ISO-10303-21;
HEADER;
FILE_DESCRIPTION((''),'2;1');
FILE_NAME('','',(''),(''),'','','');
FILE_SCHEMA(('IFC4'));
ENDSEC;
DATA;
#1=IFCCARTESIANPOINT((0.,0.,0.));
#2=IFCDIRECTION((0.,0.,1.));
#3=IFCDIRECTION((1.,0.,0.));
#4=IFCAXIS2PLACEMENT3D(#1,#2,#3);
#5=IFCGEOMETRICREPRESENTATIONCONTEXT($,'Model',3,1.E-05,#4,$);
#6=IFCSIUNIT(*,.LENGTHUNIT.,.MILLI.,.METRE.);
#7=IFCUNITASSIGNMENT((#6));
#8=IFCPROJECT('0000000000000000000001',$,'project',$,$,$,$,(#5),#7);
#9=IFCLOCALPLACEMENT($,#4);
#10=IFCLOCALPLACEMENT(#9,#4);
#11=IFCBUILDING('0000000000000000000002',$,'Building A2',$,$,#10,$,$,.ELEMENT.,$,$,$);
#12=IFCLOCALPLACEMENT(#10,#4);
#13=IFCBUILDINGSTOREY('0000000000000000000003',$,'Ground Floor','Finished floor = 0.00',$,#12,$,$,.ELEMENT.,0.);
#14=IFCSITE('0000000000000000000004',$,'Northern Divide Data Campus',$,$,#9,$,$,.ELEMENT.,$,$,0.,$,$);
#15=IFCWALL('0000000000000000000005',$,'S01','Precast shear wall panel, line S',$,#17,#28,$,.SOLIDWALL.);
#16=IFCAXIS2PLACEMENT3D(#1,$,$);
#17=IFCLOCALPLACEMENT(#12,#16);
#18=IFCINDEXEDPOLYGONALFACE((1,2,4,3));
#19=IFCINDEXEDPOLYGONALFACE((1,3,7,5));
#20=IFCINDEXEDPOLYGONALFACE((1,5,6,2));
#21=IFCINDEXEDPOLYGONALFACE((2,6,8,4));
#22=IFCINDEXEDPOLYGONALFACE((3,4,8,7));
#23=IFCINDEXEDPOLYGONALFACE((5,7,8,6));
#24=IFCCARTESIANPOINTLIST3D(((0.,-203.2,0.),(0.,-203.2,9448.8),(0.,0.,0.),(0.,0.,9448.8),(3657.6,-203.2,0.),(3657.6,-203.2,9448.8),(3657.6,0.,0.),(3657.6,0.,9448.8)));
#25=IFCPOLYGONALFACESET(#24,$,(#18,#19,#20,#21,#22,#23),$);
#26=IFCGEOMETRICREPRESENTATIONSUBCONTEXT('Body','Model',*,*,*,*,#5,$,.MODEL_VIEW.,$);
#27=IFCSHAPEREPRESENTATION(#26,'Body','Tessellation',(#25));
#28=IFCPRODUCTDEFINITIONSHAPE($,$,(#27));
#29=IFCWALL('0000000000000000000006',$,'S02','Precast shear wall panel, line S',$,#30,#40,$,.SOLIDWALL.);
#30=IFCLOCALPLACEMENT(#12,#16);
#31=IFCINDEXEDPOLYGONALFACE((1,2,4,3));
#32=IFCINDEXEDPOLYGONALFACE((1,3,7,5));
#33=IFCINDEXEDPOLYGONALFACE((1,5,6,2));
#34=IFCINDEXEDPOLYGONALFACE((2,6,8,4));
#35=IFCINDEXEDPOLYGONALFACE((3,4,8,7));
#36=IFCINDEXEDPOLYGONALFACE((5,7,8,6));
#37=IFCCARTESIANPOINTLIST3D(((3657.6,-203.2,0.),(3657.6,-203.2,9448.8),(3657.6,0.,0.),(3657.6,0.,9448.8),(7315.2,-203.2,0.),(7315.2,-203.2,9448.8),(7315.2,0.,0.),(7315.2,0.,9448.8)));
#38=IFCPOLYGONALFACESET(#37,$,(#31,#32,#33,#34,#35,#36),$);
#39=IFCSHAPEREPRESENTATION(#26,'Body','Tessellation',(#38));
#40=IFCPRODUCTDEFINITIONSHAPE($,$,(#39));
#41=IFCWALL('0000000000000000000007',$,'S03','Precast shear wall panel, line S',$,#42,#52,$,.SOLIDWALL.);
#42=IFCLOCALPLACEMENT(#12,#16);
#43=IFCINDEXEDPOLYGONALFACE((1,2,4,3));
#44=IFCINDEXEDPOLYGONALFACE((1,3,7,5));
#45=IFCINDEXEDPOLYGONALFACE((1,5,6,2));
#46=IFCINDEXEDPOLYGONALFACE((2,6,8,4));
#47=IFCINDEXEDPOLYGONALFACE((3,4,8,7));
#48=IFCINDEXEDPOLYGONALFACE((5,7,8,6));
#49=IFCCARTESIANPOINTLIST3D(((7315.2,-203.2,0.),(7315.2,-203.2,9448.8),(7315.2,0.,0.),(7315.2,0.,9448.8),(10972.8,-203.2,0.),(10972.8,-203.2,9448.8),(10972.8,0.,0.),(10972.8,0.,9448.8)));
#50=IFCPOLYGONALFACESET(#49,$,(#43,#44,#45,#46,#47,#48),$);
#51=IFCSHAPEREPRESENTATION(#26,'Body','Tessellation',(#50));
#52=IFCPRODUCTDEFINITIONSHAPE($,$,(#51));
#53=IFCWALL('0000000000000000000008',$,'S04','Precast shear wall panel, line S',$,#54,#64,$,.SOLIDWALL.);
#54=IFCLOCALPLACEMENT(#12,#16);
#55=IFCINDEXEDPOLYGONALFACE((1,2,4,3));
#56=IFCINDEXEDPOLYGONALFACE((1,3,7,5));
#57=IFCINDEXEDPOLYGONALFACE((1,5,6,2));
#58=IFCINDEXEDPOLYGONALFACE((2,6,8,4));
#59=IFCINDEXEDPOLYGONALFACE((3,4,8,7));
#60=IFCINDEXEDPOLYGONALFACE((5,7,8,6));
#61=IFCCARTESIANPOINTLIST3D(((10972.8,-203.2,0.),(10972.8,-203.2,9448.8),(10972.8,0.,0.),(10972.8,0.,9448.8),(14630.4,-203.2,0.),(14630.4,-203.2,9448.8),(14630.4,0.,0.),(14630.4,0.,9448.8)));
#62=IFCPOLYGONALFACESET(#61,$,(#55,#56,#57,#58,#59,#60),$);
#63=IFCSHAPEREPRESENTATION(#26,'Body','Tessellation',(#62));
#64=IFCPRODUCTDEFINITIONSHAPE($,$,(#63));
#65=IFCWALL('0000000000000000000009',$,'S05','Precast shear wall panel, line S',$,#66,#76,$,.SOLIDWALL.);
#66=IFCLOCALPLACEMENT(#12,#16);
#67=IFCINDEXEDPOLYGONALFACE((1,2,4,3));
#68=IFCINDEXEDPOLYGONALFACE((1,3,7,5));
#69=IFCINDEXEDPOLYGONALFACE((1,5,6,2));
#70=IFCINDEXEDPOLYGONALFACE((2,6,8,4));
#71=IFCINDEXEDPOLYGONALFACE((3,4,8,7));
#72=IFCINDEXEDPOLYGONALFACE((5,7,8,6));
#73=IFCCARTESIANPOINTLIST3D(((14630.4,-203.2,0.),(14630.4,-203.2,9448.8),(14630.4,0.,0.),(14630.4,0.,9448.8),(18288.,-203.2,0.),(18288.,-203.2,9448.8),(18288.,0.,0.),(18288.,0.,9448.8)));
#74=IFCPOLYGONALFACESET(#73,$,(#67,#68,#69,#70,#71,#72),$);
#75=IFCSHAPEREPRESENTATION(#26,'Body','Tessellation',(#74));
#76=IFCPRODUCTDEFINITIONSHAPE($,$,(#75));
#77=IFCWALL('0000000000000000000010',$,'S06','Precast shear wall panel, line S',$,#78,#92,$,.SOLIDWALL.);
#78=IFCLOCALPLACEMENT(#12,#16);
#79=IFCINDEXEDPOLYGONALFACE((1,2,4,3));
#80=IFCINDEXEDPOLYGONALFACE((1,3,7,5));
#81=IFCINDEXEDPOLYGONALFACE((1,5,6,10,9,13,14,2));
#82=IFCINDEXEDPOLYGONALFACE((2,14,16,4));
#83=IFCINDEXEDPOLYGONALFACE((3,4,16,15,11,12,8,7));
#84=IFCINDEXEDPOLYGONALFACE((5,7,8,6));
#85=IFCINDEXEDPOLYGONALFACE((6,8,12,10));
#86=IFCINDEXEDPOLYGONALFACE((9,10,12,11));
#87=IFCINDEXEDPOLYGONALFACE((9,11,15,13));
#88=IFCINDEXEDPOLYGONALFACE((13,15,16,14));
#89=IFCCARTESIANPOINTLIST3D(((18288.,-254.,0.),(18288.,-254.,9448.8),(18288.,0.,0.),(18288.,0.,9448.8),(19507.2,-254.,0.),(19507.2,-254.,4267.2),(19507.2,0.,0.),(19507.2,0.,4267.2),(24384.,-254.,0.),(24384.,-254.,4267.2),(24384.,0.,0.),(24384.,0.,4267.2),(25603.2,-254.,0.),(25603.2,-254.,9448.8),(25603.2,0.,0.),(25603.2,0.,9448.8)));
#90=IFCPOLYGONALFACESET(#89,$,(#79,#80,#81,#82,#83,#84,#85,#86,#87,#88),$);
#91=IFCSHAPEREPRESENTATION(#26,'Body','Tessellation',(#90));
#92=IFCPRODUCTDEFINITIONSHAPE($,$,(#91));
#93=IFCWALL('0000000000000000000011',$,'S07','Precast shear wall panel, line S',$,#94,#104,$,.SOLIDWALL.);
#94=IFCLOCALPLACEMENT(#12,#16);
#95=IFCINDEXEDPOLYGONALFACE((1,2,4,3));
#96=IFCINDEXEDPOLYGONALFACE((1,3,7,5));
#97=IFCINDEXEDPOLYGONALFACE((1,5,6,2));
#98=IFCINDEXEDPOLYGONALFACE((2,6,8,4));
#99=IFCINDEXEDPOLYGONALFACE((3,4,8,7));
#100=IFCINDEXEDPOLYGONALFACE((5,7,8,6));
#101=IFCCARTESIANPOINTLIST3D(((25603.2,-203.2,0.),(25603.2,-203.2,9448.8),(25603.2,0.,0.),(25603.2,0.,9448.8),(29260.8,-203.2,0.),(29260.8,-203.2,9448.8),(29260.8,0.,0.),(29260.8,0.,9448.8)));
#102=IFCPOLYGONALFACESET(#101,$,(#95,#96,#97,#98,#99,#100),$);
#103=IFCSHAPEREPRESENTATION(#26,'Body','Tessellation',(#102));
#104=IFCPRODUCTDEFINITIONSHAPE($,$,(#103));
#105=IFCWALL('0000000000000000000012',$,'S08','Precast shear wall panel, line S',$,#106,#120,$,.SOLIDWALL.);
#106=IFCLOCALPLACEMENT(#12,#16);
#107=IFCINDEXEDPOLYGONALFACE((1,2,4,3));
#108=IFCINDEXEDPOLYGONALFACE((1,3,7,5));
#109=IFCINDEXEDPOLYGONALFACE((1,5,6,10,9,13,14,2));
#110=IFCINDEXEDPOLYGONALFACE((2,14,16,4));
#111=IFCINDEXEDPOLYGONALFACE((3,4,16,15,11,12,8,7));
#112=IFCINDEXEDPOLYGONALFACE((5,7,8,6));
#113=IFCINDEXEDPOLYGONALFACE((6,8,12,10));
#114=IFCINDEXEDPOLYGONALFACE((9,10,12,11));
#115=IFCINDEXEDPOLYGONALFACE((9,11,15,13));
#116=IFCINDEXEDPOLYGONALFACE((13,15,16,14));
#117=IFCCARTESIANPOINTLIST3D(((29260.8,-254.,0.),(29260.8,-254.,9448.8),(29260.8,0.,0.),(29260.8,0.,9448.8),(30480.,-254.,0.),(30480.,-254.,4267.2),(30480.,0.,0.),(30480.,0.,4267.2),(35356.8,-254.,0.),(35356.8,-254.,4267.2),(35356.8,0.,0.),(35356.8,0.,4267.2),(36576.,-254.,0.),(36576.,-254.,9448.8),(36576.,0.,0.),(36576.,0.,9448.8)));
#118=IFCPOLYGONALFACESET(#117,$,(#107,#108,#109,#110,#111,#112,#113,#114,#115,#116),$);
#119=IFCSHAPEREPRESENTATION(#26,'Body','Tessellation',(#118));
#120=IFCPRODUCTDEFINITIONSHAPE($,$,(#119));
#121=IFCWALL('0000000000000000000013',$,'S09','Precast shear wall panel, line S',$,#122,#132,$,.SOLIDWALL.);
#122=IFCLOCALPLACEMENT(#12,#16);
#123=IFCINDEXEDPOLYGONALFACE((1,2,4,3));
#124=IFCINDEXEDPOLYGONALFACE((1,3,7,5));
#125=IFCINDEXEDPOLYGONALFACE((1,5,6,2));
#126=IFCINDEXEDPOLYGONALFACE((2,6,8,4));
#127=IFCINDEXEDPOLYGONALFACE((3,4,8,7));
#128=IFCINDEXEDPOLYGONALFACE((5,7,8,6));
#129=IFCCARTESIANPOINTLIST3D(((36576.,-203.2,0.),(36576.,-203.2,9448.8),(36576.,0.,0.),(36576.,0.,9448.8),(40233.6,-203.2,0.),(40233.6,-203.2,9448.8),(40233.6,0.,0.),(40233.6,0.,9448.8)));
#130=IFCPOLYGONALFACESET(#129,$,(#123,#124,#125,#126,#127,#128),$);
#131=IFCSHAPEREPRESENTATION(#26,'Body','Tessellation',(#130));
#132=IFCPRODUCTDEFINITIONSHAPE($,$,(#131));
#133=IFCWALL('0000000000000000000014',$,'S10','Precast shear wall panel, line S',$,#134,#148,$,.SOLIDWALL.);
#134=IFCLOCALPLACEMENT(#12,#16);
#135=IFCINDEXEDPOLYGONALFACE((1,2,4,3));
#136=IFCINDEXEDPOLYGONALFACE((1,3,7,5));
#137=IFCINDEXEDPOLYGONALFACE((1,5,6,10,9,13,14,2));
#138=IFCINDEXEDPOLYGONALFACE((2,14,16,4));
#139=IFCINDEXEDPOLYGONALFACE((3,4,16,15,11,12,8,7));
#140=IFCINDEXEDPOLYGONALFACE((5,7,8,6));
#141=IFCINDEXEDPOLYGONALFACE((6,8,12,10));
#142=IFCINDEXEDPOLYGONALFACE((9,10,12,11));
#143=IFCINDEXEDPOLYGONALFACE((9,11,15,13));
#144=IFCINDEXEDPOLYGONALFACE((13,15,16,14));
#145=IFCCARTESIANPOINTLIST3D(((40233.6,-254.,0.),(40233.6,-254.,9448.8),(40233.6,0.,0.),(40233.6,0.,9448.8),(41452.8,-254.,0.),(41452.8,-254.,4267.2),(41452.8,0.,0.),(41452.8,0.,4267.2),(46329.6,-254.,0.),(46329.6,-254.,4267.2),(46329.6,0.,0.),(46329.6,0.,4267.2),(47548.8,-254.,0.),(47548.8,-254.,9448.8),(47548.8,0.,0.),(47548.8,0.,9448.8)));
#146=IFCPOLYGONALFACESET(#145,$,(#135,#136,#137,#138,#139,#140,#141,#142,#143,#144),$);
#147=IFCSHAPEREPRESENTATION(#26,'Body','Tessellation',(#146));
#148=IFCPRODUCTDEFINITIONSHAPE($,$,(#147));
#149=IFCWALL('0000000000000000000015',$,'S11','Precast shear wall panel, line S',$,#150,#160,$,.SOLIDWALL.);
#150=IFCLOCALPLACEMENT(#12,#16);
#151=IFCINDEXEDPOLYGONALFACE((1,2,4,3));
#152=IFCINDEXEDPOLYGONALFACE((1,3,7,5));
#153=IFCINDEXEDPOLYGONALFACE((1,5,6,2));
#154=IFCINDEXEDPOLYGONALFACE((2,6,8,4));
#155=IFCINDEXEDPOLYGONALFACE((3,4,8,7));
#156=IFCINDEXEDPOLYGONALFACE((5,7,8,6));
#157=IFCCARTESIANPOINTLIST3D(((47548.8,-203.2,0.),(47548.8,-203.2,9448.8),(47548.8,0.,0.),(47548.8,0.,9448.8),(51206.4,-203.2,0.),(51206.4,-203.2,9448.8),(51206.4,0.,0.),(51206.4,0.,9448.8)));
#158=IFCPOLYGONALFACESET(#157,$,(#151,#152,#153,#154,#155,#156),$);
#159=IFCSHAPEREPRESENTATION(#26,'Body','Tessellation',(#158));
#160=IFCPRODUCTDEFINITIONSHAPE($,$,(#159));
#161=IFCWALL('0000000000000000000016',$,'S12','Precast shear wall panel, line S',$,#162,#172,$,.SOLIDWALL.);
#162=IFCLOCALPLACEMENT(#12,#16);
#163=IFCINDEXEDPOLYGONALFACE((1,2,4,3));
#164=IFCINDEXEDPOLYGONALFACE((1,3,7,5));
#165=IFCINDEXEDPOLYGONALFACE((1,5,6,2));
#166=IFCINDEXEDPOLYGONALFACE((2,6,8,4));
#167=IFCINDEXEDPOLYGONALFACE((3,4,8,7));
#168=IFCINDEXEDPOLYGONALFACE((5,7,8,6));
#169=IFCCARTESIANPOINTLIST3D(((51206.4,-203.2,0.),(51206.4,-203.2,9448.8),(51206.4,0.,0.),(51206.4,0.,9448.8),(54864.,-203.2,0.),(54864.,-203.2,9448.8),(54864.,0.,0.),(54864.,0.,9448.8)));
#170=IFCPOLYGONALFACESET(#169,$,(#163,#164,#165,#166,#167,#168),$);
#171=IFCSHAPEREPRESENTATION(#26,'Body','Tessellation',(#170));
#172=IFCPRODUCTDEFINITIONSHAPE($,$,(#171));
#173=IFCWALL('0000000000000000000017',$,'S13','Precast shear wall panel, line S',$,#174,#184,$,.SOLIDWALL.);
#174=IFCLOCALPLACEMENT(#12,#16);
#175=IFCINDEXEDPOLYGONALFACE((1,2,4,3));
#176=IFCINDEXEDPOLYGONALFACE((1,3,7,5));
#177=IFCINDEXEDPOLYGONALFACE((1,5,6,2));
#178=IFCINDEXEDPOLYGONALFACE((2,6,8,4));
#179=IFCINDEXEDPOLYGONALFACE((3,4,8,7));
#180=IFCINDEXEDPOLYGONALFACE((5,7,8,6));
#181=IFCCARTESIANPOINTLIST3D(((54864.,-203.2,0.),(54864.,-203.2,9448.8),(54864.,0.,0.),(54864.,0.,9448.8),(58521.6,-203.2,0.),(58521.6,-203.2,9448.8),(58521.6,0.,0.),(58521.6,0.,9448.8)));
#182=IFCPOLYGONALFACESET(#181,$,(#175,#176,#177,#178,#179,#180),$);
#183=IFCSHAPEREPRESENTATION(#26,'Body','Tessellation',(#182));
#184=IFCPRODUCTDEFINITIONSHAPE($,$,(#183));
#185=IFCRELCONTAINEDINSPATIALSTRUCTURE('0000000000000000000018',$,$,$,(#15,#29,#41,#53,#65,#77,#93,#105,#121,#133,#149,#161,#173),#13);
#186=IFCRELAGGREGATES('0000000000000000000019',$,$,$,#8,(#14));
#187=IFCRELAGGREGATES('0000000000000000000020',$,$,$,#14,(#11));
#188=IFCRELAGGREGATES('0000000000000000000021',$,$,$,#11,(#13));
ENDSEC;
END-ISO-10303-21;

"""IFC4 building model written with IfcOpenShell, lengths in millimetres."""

from ifc_helpers import new_model, si_unit, origin, origin_with_axes, place, context, subcontext, project, spatial, polyline, outline, extrude, element, save


model = new_model("IFC4")

# Units and contexts
model_context = context("Model", 3, precision=1e-05, world=origin_with_axes())
body_context = subcontext(model_context, "Body", "Model", "MODEL_VIEW")
ifc_project = project(units=[si_unit("LENGTHUNIT", "METRE", prefix="MILLI")], contexts=[model_context])

# Site, building, storey
site_placement = place(None, origin_with_axes())
site = spatial("IfcSite", under=ifc_project, at=site_placement, Name="Northern Divide Data Campus", CompositionType="ELEMENT", RefElevation=0.0)
building_placement = place(site_placement, origin_with_axes())
building = spatial("IfcBuilding", under=site, at=building_placement, Name="Building A2", CompositionType="ELEMENT")
storey_placement = place(building_placement, origin_with_axes())
storey = spatial("IfcBuildingStorey", under=building, at=storey_placement, Name="Ground Floor", Description="Finished floor = 0.00", CompositionType="ELEMENT", Elevation=0.0)

# Walls
wall_1_placement = place(storey_placement, origin_with_axes())
element("IfcWall", 1, at=wall_1_placement, inside=storey, Name="S01", Description="Precast shear wall panel, line S", PredefinedType="SOLIDWALL", context=body_context, shape_type="SweptSolid", body=[
    extrude(outline(polyline([(0.0, -203.2), (3657.6, -203.2), (3657.6, 0.0), (0.0, 0.0), (0.0, -203.2)])), origin(), (0.0, 0.0, 1.0), 9448.8),
])
wall_2_placement = place(storey_placement, origin_with_axes())
element("IfcWall", 2, at=wall_2_placement, inside=storey, Name="S02", Description="Precast shear wall panel, line S", PredefinedType="SOLIDWALL", context=body_context, shape_type="SweptSolid", body=[
    extrude(outline(polyline([(3657.6, -203.2), (7315.2, -203.2), (7315.2, 0.0), (3657.6, 0.0), (3657.6, -203.2)])), origin(), (0.0, 0.0, 1.0), 9448.8),
])
wall_3_placement = place(storey_placement, origin_with_axes())
element("IfcWall", 3, at=wall_3_placement, inside=storey, Name="S03", Description="Precast shear wall panel, line S", PredefinedType="SOLIDWALL", context=body_context, shape_type="SweptSolid", body=[
    extrude(outline(polyline([(7315.2, -203.2), (10972.8, -203.2), (10972.8, 0.0), (7315.2, 0.0), (7315.2, -203.2)])), origin(), (0.0, 0.0, 1.0), 9448.8),
])
wall_4_placement = place(storey_placement, origin_with_axes())
element("IfcWall", 4, at=wall_4_placement, inside=storey, Name="S04", Description="Precast shear wall panel, line S", PredefinedType="SOLIDWALL", context=body_context, shape_type="SweptSolid", body=[
    extrude(outline(polyline([(10972.8, -203.2), (14630.4, -203.2), (14630.4, 0.0), (10972.8, 0.0), (10972.8, -203.2)])), origin(), (0.0, 0.0, 1.0), 9448.8),
])
wall_5_placement = place(storey_placement, origin_with_axes())
element("IfcWall", 5, at=wall_5_placement, inside=storey, Name="S05", Description="Precast shear wall panel, line S", PredefinedType="SOLIDWALL", context=body_context, shape_type="SweptSolid", body=[
    extrude(outline(polyline([(14630.4, -203.2), (18288.0, -203.2), (18288.0, 0.0), (14630.4, 0.0), (14630.4, -203.2)])), origin(), (0.0, 0.0, 1.0), 9448.8),
])

# Wall, opening
wall_6_placement = place(storey_placement, origin_with_axes())
wall_6 = element("IfcWall", 6, at=wall_6_placement, inside=storey, Name="S06", Description="Precast shear wall panel, line S", PredefinedType="SOLIDWALL", context=body_context, shape_type="SweptSolid", body=[
    extrude(outline(polyline([(18288.0, -254.0), (25603.2, -254.0), (25603.2, 0.0), (18288.0, 0.0), (18288.0, -254.0)])), origin(), (0.0, 0.0, 1.0), 9448.8),
])
opening_1_placement = place(storey_placement, origin_with_axes())
element("IfcOpeningElement", 7, at=opening_1_placement, cuts=wall_6, PredefinedType="OPENING", context=body_context, shape_type="SweptSolid", body=[
    extrude(outline(polyline([(19507.2, -254.0), (24384.0, -254.0), (24384.0, 0.0), (19507.2, 0.0), (19507.2, -254.0)])), origin_with_axes(), (0.0, 0.0, 1.0), 4267.2),
])

# Wall
wall_7_placement = place(storey_placement, origin_with_axes())
element("IfcWall", 8, at=wall_7_placement, inside=storey, Name="S07", Description="Precast shear wall panel, line S", PredefinedType="SOLIDWALL", context=body_context, shape_type="SweptSolid", body=[
    extrude(outline(polyline([(25603.2, -203.2), (29260.8, -203.2), (29260.8, 0.0), (25603.2, 0.0), (25603.2, -203.2)])), origin(), (0.0, 0.0, 1.0), 9448.8),
])

# Wall, opening
wall_8_placement = place(storey_placement, origin_with_axes())
wall_8 = element("IfcWall", 9, at=wall_8_placement, inside=storey, Name="S08", Description="Precast shear wall panel, line S", PredefinedType="SOLIDWALL", context=body_context, shape_type="SweptSolid", body=[
    extrude(outline(polyline([(29260.8, -254.0), (36576.0, -254.0), (36576.0, 0.0), (29260.8, 0.0), (29260.8, -254.0)])), origin(), (0.0, 0.0, 1.0), 9448.8),
])
opening_2_placement = place(storey_placement, origin_with_axes())
element("IfcOpeningElement", 10, at=opening_2_placement, cuts=wall_8, PredefinedType="OPENING", context=body_context, shape_type="SweptSolid", body=[
    extrude(outline(polyline([(30480.0, -254.0), (35356.8, -254.0), (35356.8, 0.0), (30480.0, 0.0), (30480.0, -254.0)])), origin_with_axes(), (0.0, 0.0, 1.0), 4267.2),
])

# Wall
wall_9_placement = place(storey_placement, origin_with_axes())
element("IfcWall", 11, at=wall_9_placement, inside=storey, Name="S09", Description="Precast shear wall panel, line S", PredefinedType="SOLIDWALL", context=body_context, shape_type="SweptSolid", body=[
    extrude(outline(polyline([(36576.0, -203.2), (40233.6, -203.2), (40233.6, 0.0), (36576.0, 0.0), (36576.0, -203.2)])), origin(), (0.0, 0.0, 1.0), 9448.8),
])

# Wall, opening
wall_10_placement = place(storey_placement, origin_with_axes())
wall_10 = element("IfcWall", 12, at=wall_10_placement, inside=storey, Name="S10", Description="Precast shear wall panel, line S", PredefinedType="SOLIDWALL", context=body_context, shape_type="SweptSolid", body=[
    extrude(outline(polyline([(40233.6, -254.0), (47548.8, -254.0), (47548.8, 0.0), (40233.6, 0.0), (40233.6, -254.0)])), origin(), (0.0, 0.0, 1.0), 9448.8),
])
opening_3_placement = place(storey_placement, origin_with_axes())
element("IfcOpeningElement", 13, at=opening_3_placement, cuts=wall_10, PredefinedType="OPENING", context=body_context, shape_type="SweptSolid", body=[
    extrude(outline(polyline([(41452.8, -254.0), (46329.6, -254.0), (46329.6, 0.0), (41452.8, 0.0), (41452.8, -254.0)])), origin_with_axes(), (0.0, 0.0, 1.0), 4267.2),
])

# Walls
wall_11_placement = place(storey_placement, origin_with_axes())
element("IfcWall", 14, at=wall_11_placement, inside=storey, Name="S11", Description="Precast shear wall panel, line S", PredefinedType="SOLIDWALL", context=body_context, shape_type="SweptSolid", body=[
    extrude(outline(polyline([(47548.8, -203.2), (51206.4, -203.2), (51206.4, 0.0), (47548.8, 0.0), (47548.8, -203.2)])), origin(), (0.0, 0.0, 1.0), 9448.8),
])
wall_12_placement = place(storey_placement, origin_with_axes())
element("IfcWall", 15, at=wall_12_placement, inside=storey, Name="S12", Description="Precast shear wall panel, line S", PredefinedType="SOLIDWALL", context=body_context, shape_type="SweptSolid", body=[
    extrude(outline(polyline([(51206.4, -203.2), (54864.0, -203.2), (54864.0, 0.0), (51206.4, 0.0), (51206.4, -203.2)])), origin(), (0.0, 0.0, 1.0), 9448.8),
])
wall_13_placement = place(storey_placement, origin_with_axes())
element("IfcWall", 16, at=wall_13_placement, inside=storey, Name="S13", Description="Precast shear wall panel, line S", PredefinedType="SOLIDWALL", context=body_context, shape_type="SweptSolid", body=[
    extrude(outline(polyline([(54864.0, -203.2), (58521.6, -203.2), (58521.6, 0.0), (54864.0, 0.0), (54864.0, -203.2)])), origin(), (0.0, 0.0, 1.0), 9448.8),
])

save(model, "model.ifc")
